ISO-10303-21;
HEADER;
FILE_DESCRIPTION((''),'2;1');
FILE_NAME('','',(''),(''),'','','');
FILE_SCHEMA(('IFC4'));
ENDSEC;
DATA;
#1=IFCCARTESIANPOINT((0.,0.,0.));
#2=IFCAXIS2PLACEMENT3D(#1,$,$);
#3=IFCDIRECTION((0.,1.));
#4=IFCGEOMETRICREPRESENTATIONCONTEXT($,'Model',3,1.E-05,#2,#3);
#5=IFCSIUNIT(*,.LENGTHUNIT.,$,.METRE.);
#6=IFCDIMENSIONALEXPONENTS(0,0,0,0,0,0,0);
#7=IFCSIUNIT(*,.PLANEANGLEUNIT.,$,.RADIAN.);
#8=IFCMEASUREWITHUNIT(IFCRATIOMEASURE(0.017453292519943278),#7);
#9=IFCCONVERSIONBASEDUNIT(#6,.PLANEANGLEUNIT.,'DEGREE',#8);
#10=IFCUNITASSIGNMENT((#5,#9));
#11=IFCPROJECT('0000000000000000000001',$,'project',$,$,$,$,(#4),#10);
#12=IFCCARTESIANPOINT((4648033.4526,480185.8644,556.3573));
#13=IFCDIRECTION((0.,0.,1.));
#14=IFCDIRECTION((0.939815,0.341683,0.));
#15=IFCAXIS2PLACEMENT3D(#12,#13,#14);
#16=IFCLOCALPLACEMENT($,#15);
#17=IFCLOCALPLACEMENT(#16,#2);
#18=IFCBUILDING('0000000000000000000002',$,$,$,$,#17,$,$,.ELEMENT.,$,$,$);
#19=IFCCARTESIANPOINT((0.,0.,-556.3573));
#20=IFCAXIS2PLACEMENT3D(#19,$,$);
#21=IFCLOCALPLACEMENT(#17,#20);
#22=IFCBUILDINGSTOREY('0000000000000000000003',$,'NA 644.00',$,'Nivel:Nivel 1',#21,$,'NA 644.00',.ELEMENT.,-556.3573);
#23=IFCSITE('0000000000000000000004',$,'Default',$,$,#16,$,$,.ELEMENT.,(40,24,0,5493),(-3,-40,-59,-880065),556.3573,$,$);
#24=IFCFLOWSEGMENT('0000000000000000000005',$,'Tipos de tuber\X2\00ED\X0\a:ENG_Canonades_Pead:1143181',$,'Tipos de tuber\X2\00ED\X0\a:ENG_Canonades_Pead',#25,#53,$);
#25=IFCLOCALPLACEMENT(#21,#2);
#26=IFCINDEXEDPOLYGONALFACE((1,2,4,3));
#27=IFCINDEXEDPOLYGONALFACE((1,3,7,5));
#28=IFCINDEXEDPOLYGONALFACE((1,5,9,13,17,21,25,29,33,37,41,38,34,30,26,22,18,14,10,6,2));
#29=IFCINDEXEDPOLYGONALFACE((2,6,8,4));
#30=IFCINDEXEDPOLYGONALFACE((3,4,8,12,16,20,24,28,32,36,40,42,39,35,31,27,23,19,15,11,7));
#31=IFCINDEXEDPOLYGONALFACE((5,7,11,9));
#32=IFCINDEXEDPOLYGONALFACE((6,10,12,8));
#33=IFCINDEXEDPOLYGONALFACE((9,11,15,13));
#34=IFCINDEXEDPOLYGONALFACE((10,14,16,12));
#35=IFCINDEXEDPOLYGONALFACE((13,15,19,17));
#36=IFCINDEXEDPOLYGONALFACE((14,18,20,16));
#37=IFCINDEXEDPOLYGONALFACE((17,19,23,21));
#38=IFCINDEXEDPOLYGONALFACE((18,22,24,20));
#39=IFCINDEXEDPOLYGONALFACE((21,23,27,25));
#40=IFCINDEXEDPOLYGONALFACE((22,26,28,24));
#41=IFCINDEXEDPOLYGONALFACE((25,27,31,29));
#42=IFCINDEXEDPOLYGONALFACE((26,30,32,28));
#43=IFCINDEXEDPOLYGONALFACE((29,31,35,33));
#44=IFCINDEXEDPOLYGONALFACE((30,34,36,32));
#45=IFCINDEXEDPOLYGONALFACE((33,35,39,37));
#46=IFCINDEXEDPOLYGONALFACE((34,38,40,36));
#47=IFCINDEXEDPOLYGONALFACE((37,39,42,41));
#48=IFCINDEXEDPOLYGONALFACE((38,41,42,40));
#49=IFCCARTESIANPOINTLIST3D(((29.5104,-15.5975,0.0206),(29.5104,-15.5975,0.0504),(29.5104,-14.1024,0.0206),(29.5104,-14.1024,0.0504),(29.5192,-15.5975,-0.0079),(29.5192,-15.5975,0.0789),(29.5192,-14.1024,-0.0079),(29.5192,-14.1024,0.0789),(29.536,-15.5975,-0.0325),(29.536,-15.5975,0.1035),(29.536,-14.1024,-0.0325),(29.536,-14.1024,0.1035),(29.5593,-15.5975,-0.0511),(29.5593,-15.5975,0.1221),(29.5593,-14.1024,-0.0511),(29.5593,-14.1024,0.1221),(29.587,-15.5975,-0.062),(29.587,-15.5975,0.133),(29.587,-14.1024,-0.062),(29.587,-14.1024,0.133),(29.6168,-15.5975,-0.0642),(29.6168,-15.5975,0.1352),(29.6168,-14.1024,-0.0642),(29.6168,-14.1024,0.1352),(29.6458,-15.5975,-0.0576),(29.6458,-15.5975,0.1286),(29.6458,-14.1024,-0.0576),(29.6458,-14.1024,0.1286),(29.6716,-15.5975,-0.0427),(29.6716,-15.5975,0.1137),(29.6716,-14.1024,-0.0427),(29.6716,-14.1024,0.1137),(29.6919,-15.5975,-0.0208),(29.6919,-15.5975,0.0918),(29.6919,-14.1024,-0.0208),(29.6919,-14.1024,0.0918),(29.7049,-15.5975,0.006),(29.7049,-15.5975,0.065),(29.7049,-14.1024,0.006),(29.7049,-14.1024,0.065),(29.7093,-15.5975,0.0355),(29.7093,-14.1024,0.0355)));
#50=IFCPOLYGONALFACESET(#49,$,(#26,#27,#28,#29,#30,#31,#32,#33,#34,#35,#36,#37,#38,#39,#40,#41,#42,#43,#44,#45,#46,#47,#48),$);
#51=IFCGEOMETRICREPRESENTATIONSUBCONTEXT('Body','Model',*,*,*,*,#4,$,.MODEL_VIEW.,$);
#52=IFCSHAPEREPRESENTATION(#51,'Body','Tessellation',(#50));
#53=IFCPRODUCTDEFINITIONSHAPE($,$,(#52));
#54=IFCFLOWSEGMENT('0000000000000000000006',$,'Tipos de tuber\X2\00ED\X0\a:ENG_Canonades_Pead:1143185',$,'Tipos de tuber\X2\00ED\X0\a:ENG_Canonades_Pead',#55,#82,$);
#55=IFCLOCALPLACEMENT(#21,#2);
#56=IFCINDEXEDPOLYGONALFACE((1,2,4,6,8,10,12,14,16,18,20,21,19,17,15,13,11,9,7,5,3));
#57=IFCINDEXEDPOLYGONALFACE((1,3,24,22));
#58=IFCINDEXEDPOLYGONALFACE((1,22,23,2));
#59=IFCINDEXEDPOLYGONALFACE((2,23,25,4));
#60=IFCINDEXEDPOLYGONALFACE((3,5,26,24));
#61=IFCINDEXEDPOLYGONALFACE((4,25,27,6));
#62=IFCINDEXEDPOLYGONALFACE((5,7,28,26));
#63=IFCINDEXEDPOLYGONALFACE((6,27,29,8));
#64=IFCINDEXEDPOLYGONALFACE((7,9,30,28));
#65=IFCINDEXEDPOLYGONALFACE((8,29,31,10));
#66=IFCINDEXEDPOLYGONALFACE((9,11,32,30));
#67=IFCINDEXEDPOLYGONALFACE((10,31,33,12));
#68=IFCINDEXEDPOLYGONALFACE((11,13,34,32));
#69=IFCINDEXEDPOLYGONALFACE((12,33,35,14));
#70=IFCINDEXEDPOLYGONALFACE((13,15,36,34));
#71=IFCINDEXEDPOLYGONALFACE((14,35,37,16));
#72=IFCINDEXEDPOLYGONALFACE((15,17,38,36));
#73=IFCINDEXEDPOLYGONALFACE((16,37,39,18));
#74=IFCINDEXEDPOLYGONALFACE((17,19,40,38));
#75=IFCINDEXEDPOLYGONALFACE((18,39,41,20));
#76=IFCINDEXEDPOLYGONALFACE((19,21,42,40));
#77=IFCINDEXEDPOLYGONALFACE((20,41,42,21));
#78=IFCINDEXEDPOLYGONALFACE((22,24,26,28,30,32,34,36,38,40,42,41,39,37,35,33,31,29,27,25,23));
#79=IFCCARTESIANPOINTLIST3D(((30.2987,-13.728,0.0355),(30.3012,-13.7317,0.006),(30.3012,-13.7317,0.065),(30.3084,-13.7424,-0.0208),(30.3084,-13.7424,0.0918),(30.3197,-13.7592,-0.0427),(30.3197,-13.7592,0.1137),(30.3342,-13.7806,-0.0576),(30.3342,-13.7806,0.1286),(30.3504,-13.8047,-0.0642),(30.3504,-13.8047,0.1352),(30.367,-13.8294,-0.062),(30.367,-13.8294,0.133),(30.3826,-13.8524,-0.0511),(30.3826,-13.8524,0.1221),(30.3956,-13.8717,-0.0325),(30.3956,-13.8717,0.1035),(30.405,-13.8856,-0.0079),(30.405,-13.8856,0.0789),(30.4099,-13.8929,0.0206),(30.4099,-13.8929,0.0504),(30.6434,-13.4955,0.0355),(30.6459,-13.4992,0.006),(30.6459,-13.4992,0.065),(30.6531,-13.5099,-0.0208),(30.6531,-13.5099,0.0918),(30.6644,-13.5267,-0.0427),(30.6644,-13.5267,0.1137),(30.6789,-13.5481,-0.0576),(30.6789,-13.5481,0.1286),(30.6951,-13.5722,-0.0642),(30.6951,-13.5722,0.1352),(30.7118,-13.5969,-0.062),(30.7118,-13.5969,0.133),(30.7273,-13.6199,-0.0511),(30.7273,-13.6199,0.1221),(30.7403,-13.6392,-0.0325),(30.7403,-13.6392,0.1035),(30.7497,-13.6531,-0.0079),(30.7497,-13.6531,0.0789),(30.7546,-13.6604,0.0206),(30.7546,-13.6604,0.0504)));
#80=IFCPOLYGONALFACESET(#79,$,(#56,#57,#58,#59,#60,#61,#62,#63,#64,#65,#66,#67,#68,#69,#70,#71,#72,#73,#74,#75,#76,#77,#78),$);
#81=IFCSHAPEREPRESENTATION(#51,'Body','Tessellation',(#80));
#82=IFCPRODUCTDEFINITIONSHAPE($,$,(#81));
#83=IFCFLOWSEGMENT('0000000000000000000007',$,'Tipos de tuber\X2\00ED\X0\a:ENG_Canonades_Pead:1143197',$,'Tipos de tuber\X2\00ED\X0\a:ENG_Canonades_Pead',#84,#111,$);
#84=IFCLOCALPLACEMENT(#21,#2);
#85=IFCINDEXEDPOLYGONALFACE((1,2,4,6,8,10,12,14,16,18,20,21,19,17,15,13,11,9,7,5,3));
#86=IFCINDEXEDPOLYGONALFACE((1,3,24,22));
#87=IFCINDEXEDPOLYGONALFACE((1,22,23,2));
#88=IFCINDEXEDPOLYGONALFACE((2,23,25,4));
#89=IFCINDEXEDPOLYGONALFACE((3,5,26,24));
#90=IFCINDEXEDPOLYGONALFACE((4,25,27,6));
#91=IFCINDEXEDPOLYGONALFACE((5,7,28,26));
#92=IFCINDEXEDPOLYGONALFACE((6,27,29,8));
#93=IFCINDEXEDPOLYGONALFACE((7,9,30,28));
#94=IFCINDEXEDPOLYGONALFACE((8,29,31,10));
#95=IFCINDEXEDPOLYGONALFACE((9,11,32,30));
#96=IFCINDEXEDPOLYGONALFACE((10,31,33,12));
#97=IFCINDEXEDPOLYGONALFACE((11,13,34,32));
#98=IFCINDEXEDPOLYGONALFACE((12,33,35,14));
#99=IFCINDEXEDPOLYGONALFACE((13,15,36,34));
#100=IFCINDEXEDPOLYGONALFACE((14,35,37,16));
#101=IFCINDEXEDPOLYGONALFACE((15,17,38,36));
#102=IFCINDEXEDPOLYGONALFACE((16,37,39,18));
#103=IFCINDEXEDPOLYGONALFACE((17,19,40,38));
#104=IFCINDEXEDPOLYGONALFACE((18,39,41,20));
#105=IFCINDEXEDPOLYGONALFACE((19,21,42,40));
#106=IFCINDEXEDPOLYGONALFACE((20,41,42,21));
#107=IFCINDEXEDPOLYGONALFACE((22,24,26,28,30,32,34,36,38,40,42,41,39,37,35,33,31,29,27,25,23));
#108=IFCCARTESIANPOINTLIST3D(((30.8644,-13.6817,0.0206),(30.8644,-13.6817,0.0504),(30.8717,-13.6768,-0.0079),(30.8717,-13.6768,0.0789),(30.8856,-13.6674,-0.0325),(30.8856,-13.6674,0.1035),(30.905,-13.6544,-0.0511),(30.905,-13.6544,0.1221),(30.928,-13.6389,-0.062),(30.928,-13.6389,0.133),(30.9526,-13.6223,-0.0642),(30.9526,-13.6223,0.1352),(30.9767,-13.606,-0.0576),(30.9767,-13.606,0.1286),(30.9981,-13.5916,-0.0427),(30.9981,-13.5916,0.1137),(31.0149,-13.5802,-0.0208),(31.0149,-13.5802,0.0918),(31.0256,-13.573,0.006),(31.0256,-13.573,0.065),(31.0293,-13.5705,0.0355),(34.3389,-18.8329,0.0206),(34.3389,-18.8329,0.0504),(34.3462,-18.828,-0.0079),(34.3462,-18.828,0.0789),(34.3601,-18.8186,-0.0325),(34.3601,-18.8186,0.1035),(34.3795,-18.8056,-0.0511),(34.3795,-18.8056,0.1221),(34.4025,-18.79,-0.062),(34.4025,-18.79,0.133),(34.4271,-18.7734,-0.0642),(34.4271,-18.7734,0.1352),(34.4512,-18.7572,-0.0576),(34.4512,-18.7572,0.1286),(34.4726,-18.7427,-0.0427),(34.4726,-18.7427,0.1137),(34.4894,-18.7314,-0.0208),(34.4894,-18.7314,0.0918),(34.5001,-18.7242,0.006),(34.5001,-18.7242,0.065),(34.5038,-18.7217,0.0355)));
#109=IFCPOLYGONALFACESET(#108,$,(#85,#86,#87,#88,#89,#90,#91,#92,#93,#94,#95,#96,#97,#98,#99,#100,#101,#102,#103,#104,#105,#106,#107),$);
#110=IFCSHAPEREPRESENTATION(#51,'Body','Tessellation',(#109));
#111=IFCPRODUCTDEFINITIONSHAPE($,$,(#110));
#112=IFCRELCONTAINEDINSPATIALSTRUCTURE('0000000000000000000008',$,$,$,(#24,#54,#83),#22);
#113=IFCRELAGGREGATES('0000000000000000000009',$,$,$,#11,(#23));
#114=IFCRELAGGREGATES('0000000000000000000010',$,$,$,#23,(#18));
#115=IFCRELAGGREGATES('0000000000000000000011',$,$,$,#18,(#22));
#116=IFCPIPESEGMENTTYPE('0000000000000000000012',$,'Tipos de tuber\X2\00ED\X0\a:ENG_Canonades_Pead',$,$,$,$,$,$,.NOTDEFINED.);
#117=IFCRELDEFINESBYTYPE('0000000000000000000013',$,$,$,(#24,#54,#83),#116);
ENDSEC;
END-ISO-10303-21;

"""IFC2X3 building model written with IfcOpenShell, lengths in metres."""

from ifc_helpers import new_model, entity, si_unit, converted_unit, direction, frame, frame_2d, origin, origin_2d_with_axis, place, context, subcontext, project, spatial, circle, extrude, type_object, element, save


model = new_model("IFC2X3")

# Units and contexts
model_context = context("Model", 3, precision=1e-05, world=origin(), true_north=direction((0.0, 1.0)))
body_context = subcontext(model_context, "Body", "Model", "MODEL_VIEW")
ifc_project = project(units=[si_unit("LENGTHUNIT", "METRE"), converted_unit("PLANEANGLEUNIT", "DEGREE", entity("IfcRatioMeasure", 0.017453292519943278), si_unit("PLANEANGLEUNIT", "RADIAN"), dimensions=[0, 0, 0, 0, 0, 0, 0])], contexts=[model_context])

# Site, building, storey
site_placement = place(None, frame((4648033.4526, 480185.8644, 556.3573), z_axis=(0.0, 0.0, 1.0), x_axis=(0.939815, 0.341683, 0.0)))
site = spatial("IfcSite", under=ifc_project, at=site_placement, Name="Default", CompositionType="ELEMENT", RefLatitude=(40, 24, 0, 5493), RefLongitude=(-3, -40, -59, -880065), RefElevation=556.3573)
building_placement = place(site_placement, origin())
building = spatial("IfcBuilding", under=site, at=building_placement, CompositionType="ELEMENT")
storey_placement = place(building_placement, frame((0.0, 0.0, -556.3573)))
storey = spatial("IfcBuildingStorey", under=building, at=storey_placement, Name="NA 644.00", ObjectType="Nivel:Nivel 1", LongName="NA 644.00", CompositionType="ELEMENT", Elevation=-556.3573)

# Flow segments
pipe_segment_type = type_object("IfcPipeSegmentType", Name="Tipos de tubería:ENG_Canonades_Pead", PredefinedType="NOTDEFINED")
flow_segment_1_placement = place(storey_placement, origin())
element("IfcFlowSegment", 1, at=flow_segment_1_placement, inside=storey, type_object=pipe_segment_type, Name="Tipos de tubería:ENG_Canonades_Pead:1143181", ObjectType="Tipos de tubería:ENG_Canonades_Pead", context=body_context, shape_type="SweptSolid", body=[
    extrude(circle(Radius=0.1, at=origin_2d_with_axis()), frame((29.6093, -15.5975, 0.0355), z_axis=(0.0, 1.0, 0.0), x_axis=(1.0, 0.0, 0.0)), (0.0, 0.0, 1.0), 1.495),
])
flow_segment_2_placement = place(storey_placement, origin())
element("IfcFlowSegment", 2, at=flow_segment_2_placement, inside=storey, type_object=pipe_segment_type, Name="Tipos de tubería:ENG_Canonades_Pead:1143185", ObjectType="Tipos de tubería:ENG_Canonades_Pead", context=body_context, shape_type="SweptSolid", body=[
    extrude(circle(Radius=0.1, at=frame_2d((0.0, 0.0), x_axis=(1.0, 0.0))), frame((30.3546, -13.8109, 0.0355), z_axis=(0.829038, 0.559193, 0.0), x_axis=(-0.559193, 0.829038, 0.0)), (0.0, 0.0, 1.0), 0.4158),
])
flow_segment_3_placement = place(storey_placement, origin())
element("IfcFlowSegment", 3, at=flow_segment_3_placement, inside=storey, type_object=pipe_segment_type, Name="Tipos de tubería:ENG_Canonades_Pead:1143197", ObjectType="Tipos de tubería:ENG_Canonades_Pead", context=body_context, shape_type="SweptSolid", body=[
    extrude(circle(Radius=0.1, at=origin_2d_with_axis()), frame((34.4209, -18.7776, 0.0355), z_axis=(-0.559193, 0.829038, 0.0), x_axis=(0.829038, 0.559193, 0.0)), (0.0, 0.0, 1.0), 6.2134),
])

save(model, "model.ifc")
